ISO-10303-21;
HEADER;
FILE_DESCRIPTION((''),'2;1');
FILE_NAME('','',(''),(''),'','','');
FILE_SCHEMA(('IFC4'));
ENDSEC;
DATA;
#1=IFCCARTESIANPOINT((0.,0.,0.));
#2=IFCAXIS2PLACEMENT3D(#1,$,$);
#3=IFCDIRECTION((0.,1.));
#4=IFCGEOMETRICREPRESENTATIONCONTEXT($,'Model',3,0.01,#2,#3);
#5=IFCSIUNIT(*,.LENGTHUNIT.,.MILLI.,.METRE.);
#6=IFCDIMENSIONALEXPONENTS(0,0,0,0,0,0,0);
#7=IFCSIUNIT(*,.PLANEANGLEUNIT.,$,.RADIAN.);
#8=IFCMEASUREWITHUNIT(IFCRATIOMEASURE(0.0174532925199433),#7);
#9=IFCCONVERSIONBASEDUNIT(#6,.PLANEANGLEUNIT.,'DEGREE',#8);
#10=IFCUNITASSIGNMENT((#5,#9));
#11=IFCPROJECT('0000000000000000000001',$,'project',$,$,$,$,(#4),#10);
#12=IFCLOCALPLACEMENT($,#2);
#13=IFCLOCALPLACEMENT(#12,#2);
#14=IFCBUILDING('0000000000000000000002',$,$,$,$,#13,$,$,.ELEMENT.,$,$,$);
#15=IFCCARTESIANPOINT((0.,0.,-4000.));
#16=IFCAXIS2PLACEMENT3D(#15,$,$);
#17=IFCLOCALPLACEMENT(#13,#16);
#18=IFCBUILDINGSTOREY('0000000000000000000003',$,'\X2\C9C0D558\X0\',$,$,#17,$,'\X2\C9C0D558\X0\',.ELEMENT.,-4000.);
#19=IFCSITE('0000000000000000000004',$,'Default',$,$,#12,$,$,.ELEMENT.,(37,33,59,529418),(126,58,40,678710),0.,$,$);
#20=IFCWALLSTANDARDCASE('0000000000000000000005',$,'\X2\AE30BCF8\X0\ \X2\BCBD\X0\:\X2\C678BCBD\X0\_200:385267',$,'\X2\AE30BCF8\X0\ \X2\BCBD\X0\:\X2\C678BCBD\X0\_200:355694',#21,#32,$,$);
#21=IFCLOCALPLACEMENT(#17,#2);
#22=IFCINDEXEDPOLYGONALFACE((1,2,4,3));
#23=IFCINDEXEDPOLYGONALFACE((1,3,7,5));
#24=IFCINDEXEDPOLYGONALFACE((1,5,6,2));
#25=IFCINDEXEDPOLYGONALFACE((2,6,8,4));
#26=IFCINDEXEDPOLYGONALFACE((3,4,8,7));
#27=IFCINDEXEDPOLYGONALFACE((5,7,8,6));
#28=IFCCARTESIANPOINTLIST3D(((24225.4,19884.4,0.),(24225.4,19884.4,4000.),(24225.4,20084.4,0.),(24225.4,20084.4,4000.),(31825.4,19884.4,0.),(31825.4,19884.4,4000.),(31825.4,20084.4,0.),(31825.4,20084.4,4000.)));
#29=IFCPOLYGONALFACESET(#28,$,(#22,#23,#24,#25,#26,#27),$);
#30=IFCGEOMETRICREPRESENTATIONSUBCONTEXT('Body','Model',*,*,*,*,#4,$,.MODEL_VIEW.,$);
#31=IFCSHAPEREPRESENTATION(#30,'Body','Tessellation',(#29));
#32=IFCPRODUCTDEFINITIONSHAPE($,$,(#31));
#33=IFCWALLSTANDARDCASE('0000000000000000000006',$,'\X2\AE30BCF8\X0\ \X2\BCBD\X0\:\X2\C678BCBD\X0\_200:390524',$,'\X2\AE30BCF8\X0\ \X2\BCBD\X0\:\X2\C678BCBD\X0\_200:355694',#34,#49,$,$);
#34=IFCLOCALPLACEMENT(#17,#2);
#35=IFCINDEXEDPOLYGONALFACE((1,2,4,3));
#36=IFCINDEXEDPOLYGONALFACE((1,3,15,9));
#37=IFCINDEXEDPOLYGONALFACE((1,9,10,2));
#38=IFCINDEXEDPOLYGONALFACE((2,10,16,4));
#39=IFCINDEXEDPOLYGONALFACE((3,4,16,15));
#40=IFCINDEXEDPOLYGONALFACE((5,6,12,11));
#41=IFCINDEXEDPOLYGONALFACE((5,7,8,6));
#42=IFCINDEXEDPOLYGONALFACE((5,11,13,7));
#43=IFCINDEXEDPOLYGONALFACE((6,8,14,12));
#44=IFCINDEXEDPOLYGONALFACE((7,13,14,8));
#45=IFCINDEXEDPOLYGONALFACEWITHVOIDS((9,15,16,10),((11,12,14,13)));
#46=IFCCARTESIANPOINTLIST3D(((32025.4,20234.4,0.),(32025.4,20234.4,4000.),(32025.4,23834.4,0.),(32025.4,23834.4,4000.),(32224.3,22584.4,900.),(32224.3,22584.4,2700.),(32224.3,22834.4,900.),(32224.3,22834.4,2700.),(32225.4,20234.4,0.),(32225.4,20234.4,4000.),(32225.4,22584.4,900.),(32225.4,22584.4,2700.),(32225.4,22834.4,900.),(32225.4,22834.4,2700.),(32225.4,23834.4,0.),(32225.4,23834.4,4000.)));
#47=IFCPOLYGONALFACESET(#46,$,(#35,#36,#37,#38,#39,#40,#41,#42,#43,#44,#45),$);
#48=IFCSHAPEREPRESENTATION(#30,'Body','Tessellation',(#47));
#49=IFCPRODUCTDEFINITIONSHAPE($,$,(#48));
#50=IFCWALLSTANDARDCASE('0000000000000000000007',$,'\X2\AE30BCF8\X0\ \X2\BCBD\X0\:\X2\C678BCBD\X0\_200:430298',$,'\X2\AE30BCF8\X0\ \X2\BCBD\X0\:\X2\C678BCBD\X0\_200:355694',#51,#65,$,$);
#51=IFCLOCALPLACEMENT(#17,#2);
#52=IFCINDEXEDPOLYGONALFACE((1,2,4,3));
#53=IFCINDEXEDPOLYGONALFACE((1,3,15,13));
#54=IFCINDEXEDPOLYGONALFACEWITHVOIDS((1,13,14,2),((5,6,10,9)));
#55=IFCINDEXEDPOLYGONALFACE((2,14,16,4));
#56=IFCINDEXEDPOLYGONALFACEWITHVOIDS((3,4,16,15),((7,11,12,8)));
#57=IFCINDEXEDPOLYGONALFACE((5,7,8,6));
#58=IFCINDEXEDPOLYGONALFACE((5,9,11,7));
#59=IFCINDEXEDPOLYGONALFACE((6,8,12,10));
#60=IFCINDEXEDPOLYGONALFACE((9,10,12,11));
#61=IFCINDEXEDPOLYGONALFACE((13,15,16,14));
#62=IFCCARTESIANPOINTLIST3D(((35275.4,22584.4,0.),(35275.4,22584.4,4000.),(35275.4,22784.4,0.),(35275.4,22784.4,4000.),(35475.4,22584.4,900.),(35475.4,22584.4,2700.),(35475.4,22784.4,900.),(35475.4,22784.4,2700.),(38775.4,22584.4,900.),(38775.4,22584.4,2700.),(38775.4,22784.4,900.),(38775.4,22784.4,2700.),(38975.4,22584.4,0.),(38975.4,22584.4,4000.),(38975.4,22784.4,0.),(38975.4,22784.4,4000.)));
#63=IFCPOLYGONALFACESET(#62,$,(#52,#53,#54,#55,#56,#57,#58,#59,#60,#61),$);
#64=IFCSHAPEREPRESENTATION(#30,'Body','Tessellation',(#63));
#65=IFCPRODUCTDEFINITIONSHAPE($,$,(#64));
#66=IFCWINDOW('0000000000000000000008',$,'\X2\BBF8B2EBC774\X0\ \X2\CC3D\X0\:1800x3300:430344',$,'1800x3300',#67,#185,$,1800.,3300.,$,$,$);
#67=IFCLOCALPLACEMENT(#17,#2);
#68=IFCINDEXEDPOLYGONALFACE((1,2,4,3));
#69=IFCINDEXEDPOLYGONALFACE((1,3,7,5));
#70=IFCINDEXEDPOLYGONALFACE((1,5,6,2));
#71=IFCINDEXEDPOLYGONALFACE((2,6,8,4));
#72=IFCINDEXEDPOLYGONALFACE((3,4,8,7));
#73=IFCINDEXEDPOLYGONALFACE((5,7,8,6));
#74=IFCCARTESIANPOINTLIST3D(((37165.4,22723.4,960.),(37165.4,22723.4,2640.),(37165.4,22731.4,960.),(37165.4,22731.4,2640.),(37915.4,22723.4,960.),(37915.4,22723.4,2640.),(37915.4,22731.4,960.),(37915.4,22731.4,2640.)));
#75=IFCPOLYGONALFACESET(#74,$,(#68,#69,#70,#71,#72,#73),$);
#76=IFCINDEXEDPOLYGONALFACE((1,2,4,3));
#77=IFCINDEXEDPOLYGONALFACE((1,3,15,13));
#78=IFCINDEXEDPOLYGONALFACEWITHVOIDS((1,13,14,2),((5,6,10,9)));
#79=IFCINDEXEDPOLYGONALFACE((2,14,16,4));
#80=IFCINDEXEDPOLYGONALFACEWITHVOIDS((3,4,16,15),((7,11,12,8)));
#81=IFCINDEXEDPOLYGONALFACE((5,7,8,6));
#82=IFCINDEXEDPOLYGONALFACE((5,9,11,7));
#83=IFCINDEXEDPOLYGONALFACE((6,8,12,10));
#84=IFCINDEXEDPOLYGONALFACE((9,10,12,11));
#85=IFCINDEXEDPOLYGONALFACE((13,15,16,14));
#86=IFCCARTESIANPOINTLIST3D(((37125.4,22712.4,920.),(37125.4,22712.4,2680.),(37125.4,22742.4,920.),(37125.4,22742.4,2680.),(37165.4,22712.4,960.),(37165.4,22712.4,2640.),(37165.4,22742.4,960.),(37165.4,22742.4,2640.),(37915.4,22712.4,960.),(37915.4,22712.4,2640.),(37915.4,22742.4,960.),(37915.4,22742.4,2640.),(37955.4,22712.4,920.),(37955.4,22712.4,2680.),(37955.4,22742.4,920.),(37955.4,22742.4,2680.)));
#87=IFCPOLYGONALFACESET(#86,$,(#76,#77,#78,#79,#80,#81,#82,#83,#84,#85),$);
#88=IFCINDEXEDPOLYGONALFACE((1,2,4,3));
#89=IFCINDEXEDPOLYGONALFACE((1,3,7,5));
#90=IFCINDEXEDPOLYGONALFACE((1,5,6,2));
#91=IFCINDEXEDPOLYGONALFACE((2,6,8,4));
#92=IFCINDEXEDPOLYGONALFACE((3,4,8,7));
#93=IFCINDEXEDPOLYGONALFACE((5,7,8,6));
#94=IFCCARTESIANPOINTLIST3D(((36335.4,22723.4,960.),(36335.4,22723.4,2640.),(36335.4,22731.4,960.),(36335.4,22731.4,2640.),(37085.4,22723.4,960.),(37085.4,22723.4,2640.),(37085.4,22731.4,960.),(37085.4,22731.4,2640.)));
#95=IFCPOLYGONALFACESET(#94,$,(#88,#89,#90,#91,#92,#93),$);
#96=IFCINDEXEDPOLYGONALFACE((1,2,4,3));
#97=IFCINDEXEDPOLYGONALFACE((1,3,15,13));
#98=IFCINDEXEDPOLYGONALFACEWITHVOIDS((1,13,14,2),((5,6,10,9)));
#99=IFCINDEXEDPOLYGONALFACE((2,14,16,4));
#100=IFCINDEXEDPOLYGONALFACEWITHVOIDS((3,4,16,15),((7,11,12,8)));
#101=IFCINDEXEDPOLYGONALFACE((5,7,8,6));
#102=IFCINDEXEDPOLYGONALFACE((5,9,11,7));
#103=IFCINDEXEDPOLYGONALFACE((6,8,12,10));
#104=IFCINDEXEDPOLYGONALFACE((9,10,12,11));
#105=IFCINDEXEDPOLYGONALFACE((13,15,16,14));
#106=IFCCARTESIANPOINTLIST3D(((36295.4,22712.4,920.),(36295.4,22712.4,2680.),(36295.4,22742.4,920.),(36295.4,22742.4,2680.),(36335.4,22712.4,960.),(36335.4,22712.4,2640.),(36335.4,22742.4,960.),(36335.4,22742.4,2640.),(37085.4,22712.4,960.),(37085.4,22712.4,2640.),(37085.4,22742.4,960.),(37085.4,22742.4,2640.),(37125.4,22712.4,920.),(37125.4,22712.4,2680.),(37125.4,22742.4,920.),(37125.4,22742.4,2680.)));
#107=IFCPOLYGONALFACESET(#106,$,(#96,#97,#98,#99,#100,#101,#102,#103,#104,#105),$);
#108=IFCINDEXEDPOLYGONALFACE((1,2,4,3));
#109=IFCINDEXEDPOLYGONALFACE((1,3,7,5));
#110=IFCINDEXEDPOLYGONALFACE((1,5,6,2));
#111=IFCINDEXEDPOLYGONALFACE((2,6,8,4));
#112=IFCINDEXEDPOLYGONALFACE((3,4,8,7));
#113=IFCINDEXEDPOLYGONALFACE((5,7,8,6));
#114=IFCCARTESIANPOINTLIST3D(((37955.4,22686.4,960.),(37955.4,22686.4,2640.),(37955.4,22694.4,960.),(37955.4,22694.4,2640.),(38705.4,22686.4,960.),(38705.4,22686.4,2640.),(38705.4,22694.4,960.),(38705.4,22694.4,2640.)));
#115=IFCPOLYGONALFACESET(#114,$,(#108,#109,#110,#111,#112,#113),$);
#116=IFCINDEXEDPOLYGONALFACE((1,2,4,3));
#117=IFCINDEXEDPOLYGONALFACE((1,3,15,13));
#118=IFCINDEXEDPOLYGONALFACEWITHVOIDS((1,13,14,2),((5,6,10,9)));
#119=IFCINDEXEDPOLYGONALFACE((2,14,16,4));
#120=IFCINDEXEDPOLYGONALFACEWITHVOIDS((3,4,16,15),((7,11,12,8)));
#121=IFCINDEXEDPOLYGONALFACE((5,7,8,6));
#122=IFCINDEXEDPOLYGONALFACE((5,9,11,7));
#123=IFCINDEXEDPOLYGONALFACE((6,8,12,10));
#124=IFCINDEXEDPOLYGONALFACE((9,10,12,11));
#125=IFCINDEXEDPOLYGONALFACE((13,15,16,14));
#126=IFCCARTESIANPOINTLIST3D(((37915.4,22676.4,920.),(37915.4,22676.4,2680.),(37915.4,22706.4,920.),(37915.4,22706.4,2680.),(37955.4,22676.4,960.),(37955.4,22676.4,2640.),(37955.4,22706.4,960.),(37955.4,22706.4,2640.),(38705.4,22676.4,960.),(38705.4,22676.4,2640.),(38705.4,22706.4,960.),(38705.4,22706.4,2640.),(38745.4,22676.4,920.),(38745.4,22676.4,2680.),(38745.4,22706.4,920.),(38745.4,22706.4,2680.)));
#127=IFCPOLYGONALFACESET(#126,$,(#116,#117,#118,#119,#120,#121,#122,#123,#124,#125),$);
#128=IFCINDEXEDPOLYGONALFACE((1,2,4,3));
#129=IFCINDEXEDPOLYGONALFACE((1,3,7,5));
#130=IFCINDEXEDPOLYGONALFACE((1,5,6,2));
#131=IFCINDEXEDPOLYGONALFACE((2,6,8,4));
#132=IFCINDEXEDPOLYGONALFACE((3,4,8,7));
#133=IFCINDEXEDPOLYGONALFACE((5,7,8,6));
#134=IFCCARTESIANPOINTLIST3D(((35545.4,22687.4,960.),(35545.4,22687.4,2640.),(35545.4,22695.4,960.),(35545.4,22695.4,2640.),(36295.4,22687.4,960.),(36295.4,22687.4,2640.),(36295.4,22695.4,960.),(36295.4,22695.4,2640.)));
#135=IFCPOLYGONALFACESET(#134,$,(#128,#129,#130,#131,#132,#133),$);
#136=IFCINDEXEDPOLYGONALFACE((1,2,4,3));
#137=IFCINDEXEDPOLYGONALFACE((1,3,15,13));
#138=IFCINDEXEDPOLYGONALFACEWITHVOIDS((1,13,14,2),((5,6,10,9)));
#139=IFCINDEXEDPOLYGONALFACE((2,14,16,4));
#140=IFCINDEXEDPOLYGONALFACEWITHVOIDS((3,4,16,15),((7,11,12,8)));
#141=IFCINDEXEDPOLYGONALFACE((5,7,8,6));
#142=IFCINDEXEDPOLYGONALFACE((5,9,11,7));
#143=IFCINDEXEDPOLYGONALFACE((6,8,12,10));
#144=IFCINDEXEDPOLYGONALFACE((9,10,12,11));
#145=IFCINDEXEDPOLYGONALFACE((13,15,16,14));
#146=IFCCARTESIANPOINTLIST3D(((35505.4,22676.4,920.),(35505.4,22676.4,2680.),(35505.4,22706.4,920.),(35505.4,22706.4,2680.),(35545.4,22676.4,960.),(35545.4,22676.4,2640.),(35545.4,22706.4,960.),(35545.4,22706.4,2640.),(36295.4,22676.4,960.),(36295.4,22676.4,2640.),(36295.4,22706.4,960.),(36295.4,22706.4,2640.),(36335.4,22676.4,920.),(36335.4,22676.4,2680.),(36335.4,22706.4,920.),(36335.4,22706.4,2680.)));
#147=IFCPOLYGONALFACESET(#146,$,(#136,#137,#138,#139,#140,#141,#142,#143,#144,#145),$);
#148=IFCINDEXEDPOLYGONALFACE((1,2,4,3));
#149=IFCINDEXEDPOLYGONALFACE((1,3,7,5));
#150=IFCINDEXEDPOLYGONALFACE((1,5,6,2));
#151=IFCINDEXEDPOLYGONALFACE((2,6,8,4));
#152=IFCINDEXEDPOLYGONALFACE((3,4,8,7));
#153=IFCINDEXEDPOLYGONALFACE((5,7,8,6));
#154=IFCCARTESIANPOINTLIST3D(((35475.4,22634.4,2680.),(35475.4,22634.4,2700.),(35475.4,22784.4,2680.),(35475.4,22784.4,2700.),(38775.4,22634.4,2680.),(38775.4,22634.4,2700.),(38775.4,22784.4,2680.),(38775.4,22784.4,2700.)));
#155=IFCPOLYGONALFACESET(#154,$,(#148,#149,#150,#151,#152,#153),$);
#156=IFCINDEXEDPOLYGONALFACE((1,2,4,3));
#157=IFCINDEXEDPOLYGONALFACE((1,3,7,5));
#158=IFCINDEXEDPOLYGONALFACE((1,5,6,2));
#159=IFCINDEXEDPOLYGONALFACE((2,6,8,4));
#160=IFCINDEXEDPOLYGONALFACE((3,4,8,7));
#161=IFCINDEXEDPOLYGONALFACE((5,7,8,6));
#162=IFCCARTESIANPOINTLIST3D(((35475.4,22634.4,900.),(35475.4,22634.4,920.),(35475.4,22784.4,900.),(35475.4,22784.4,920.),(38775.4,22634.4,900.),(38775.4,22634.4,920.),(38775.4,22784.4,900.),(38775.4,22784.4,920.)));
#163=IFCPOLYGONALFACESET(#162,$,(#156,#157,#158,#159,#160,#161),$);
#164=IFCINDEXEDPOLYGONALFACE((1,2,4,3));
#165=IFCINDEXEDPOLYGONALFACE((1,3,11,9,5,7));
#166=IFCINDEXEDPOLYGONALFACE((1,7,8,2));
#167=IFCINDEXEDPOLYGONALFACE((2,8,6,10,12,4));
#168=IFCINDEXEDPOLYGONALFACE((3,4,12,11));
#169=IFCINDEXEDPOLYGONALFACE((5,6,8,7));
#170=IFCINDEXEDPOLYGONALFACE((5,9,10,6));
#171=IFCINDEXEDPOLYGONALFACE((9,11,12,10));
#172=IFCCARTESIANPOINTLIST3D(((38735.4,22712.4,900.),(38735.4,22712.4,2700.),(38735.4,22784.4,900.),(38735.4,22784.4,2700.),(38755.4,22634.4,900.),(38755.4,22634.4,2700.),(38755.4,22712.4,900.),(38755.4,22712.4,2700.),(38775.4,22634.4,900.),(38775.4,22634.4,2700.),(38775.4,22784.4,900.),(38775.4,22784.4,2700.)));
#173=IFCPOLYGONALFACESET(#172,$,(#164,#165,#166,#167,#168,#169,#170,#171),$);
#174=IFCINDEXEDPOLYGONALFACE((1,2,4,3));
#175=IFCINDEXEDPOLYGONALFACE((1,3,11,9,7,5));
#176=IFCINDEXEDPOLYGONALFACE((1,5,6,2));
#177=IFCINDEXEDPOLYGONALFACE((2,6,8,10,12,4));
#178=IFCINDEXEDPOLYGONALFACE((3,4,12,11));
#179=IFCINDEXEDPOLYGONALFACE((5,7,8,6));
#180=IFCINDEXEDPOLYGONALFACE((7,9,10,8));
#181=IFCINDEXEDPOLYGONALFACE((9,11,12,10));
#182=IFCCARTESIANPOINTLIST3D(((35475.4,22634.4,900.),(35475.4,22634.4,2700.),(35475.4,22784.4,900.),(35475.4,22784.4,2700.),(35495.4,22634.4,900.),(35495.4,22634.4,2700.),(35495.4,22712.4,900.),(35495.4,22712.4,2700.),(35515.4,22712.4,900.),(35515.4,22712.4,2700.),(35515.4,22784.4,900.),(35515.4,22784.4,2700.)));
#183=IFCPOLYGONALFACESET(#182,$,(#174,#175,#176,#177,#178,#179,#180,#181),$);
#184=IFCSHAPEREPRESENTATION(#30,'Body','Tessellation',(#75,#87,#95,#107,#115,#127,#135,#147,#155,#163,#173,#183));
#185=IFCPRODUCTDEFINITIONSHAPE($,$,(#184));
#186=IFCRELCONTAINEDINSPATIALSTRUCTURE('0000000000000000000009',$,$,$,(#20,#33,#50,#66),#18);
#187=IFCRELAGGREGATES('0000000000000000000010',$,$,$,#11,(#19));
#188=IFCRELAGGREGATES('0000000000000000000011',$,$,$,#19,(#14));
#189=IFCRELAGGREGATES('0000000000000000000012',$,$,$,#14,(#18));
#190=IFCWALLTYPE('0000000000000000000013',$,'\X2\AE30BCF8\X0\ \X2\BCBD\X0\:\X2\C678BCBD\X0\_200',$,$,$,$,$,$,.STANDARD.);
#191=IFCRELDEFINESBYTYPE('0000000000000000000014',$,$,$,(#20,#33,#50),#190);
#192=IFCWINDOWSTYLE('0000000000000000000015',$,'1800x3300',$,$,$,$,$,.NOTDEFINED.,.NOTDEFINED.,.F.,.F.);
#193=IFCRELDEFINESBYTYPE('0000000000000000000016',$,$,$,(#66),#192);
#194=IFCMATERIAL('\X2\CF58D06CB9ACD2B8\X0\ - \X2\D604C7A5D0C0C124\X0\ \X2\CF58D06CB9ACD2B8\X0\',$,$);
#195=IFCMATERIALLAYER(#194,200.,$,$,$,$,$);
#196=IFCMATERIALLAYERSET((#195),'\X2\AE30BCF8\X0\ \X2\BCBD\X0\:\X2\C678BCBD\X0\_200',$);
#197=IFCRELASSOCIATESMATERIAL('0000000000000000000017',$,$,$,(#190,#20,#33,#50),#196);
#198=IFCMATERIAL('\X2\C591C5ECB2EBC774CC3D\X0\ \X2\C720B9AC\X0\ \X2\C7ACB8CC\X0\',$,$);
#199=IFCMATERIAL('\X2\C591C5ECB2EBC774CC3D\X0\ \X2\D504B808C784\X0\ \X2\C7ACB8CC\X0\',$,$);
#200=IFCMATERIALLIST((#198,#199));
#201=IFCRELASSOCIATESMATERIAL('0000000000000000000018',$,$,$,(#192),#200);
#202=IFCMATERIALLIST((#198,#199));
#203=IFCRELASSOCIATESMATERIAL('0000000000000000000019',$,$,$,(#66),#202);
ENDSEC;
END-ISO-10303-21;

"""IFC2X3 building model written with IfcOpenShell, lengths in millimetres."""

from ifc_helpers import new_model, entity, si_unit, converted_unit, direction, frame, frame_2d, origin, origin_2d_with_axis, place, context, subcontext, project, spatial, polyline, rectangle, outline, extrude, source, transform, mapped, material, material_list, layer, layer_set, layer_usage, type_object, type_shapes, element, fill, save


model = new_model("IFC2X3")

# Units and contexts
model_context = context("Model", 3, precision=0.01, world=origin(), true_north=direction((0.0, 1.0)))
body_context = subcontext(model_context, "Body", "Model", "MODEL_VIEW")
ifc_project = project(units=[si_unit("LENGTHUNIT", "METRE", prefix="MILLI"), converted_unit("PLANEANGLEUNIT", "DEGREE", entity("IfcRatioMeasure", 0.0174532925199433), si_unit("PLANEANGLEUNIT", "RADIAN"), dimensions=[0, 0, 0, 0, 0, 0, 0])], contexts=[model_context])

# Site, building, storey
site_placement = place(None, origin())
site = spatial("IfcSite", under=ifc_project, at=site_placement, Name="Default", CompositionType="ELEMENT", RefLatitude=(37, 33, 59, 529418), RefLongitude=(126, 58, 40, 678710), RefElevation=0.0)
building_placement = place(site_placement, origin())
building = spatial("IfcBuilding", under=site, at=building_placement, CompositionType="ELEMENT")
storey_placement = place(building_placement, frame((0.0, 0.0, -4000.0)))
storey = spatial("IfcBuildingStorey", under=building, at=storey_placement, Name="지하", LongName="지하", CompositionType="ELEMENT", Elevation=-4000.0)

# Wall
ifc_material_1 = material(Name="콘크리트 - 현장타설 콘크리트")
ifc_layer_1 = layer(ifc_material_1, 200.0)
ifc_layer_set_1 = layer_set([ifc_layer_1], Name="기본 벽:외벽_200")
ifc_layer_usage_1 = layer_usage(ifc_layer_set_1, "AXIS2", "NEGATIVE", 100.0)
wall_type_1 = type_object("IfcWallType", Name="기본 벽:외벽_200", PredefinedType="STANDARD", material=ifc_layer_set_1)
wall_1_placement = place(storey_placement, frame((31825.4, 19984.4, 0.0), z_axis=(0.0, 0.0, 1.0), x_axis=(-1.0, 0.0, 0.0)))
element("IfcWallStandardCase", 1, at=wall_1_placement, inside=storey, type_object=wall_type_1, material=ifc_layer_usage_1, Name="기본 벽:외벽_200:385267", ObjectType="기본 벽:외벽_200:355694", context=body_context, shape_type="SweptSolid", body=[
    extrude(rectangle(XDim=7600.0, YDim=200.0, at=frame_2d((3800.0, 0.0), x_axis=(-1.0, 0.0))), origin(), (0.0, 0.0, 1.0), 4000.0),
])

# Wall, opening
ifc_layer_usage_2 = layer_usage(ifc_layer_set_1, "AXIS2", "NEGATIVE", 100.0)
wall_2_placement = place(storey_placement, frame((32125.4, 23834.4, 0.0), z_axis=(0.0, 0.0, 1.0), x_axis=(0.0, -1.0, 0.0)))
wall_2 = element("IfcWallStandardCase", 2, at=wall_2_placement, inside=storey, type_object=wall_type_1, material=ifc_layer_usage_2, Name="기본 벽:외벽_200:390524", ObjectType="기본 벽:외벽_200:355694", context=body_context, shape_type="SweptSolid", body=[
    extrude(rectangle(XDim=3600.0, YDim=200.0, at=frame_2d((1800.0, 0.0), x_axis=(-1.0, 0.0))), origin(), (0.0, 0.0, 1.0), 4000.0),
])
opening_1_placement = place(wall_2_placement, origin())
element("IfcOpeningElement", 3, at=opening_1_placement, cuts=wall_2, ObjectType="Opening", context=body_context, shape_type="SweptSolid", body=[
    extrude(rectangle(XDim=1800.0, YDim=250.0, at=frame_2d((0.0, 0.0), x_axis=(0.0, 1.0))), frame((1125.0, 98.9, 1800.0), z_axis=(0.0, 1.0, 0.0), x_axis=(1.0, 0.0, 0.0)), (0.0, 0.0, 1.0), 2700.0),
])

# Wall, opening, window
ifc_layer_usage_3 = layer_usage(ifc_layer_set_1, "AXIS2", "NEGATIVE", 100.0)
wall_3_placement = place(storey_placement, frame((35275.4, 22684.4, 0.0)))
wall_3 = element("IfcWallStandardCase", 4, at=wall_3_placement, inside=storey, type_object=wall_type_1, material=ifc_layer_usage_3, Name="기본 벽:외벽_200:430298", ObjectType="기본 벽:외벽_200:355694", context=body_context, shape_type="SweptSolid", body=[
    extrude(rectangle(XDim=3700.0, YDim=200.0, at=frame_2d((1850.0, 0.0), x_axis=(-1.0, 0.0))), origin(), (0.0, 0.0, 1.0), 4000.0),
])
opening_2_placement = place(wall_3_placement, frame((200.0, -100.0, 900.0)))
opening_2 = element("IfcOpeningElement", 5, at=opening_2_placement, cuts=wall_3, ObjectType="Opening", context=body_context, shape_type="SweptSolid", body=[
    extrude(rectangle(XDim=1800.0, YDim=3300.0, at=frame_2d((900.0, 1650.0), x_axis=(1.0, 0.0))), frame((0.0, 0.0, 0.0), z_axis=(0.0, 1.0, 0.0), x_axis=(0.0, 0.0, 1.0)), (0.0, 0.0, 1.0), 200.0),
])
ifc_material_2 = material(Name="양여닫이창 유리 재료")
ifc_material_3 = material(Name="양여닫이창 프레임 재료")
ifc_material_list_1 = material_list([ifc_material_2, ifc_material_3])
ifc_material_list_2 = material_list([ifc_material_2, ifc_material_3])
window_style_1 = type_object("IfcWindowStyle", Name="1800x3300", ConstructionType="NOTDEFINED", OperationType="NOTDEFINED", ParameterTakesPrecedence=False, Sizeable=False, material=ifc_material_list_2)
shared_shape_1 = source(origin(), body_context, "Body", "SweptSolid", [
    extrude(rectangle(XDim=8.0, YDim=750.0, at=frame_2d((0.0, 0.0), x_axis=(1.0, 0.0))), frame((2065.0, 143.0, 60.0), z_axis=(0.0, 0.0, 1.0), x_axis=(0.0, 1.0, 0.0)), (0.0, 0.0, 1.0), 1680.0),
    extrude(outline(polyline([(-880.0, -415.0), (880.0, -415.0), (880.0, 415.0), (-880.0, 415.0), (-880.0, -415.0)]), holes=[polyline([(840.0, -375.0), (-840.0, -375.0), (-840.0, 375.0), (840.0, 375.0), (840.0, -375.0)])]), frame((2065.0, 128.0, 900.0), z_axis=(0.0, 1.0, 0.0), x_axis=(0.0, 0.0, -1.0)), (0.0, 0.0, 1.0), 30.0),
    extrude(rectangle(XDim=8.0, YDim=750.0, at=frame_2d((0.0, 0.0), x_axis=(1.0, 0.0))), frame((1235.0, 143.0, 60.0), z_axis=(0.0, 0.0, 1.0), x_axis=(0.0, 1.0, 0.0)), (0.0, 0.0, 1.0), 1680.0),
    extrude(outline(polyline([(-880.0, -415.0), (880.0, -415.0), (880.0, 415.0), (-880.0, 415.0), (-880.0, -415.0)]), holes=[polyline([(840.0, -375.0), (-840.0, -375.0), (-840.0, 375.0), (840.0, 375.0), (840.0, -375.0)])]), frame((1235.0, 128.0, 900.0), z_axis=(0.0, 1.0, 0.0), x_axis=(0.0, 0.0, -1.0)), (0.0, 0.0, 1.0), 30.0),
    extrude(rectangle(XDim=8.0, YDim=750.0, at=frame_2d((0.0, 0.0), x_axis=(1.0, 0.0))), frame((2855.0, 106.0, 60.0), z_axis=(0.0, 0.0, 1.0), x_axis=(0.0, 1.0, 0.0)), (0.0, 0.0, 1.0), 1680.0),
    extrude(outline(polyline([(-880.0, -415.0), (880.0, -415.0), (880.0, 415.0), (-880.0, 415.0), (-880.0, -415.0)]), holes=[polyline([(840.0, -375.0), (-840.0, -375.0), (-840.0, 375.0), (840.0, 375.0), (840.0, -375.0)])]), frame((2855.0, 92.0, 900.0), z_axis=(0.0, 1.0, 0.0), x_axis=(0.0, 0.0, -1.0)), (0.0, 0.0, 1.0), 30.0),
    extrude(rectangle(XDim=8.0, YDim=750.0, at=origin_2d_with_axis()), frame((445.0, 107.0, 60.0), z_axis=(0.0, 0.0, 1.0), x_axis=(0.0, 1.0, 0.0)), (0.0, 0.0, 1.0), 1680.0),
    extrude(outline(polyline([(-880.0, -415.0), (880.0, -415.0), (880.0, 415.0), (-880.0, 415.0), (-880.0, -415.0)]), holes=[polyline([(840.0, -375.0), (-840.0, -375.0), (-840.0, 375.0), (840.0, 375.0), (840.0, -375.0)])]), frame((445.0, 92.0, 900.0), z_axis=(0.0, 1.0, 0.0), x_axis=(0.0, 0.0, -1.0)), (0.0, 0.0, 1.0), 30.0),
    extrude(rectangle(XDim=3300.0, YDim=150.0, at=origin_2d_with_axis()), frame((1650.0, 125.0, 1780.0), z_axis=(0.0, 0.0, 1.0), x_axis=(-1.0, 0.0, 0.0)), (0.0, 0.0, 1.0), 20.0),
    extrude(rectangle(XDim=3300.0, YDim=150.0, at=origin_2d_with_axis()), frame((1650.0, 125.0, 0.0), z_axis=(0.0, 0.0, 1.0), x_axis=(-1.0, 0.0, 0.0)), (0.0, 0.0, 1.0), 20.0),
    extrude(outline(polyline([(-74.0, -20.0), (-2.0, -20.0), (-2.0, 0.0), (76.0, 0.0), (76.0, 20.0), (-74.0, 20.0), (-74.0, -20.0)])), frame((3280.0, 126.0, 0.0), z_axis=(0.0, 0.0, 1.0), x_axis=(0.0, -1.0, 0.0)), (0.0, 0.0, 1.0), 1800.0),
    extrude(outline(polyline([(-20.0, -74.0), (20.0, -74.0), (20.0, 76.0), (0.0, 76.0), (0.0, -2.0), (-20.0, -2.0), (-20.0, -74.0)])), frame((20.0, 126.0, 0.0), z_axis=(0.0, 0.0, 1.0), x_axis=(-1.0, 0.0, 0.0)), (0.0, 0.0, 1.0), 1800.0),
])
type_shapes(window_style_1, [shared_shape_1])
window_1_placement = place(opening_2_placement, origin())
window_1 = element("IfcWindow", 6, at=window_1_placement, inside=storey, type_object=window_style_1, material=ifc_material_list_1, Name="미닫이 창:1800x3300:430344", ObjectType="1800x3300", OverallHeight=1800.0, OverallWidth=3300.0, context=body_context, shape_type="MappedRepresentation", body=[
    mapped(shared_shape_1, transform((0.0, 0.0, 0.0), scale=1.0)),
])
fill(opening_2, window_1)

save(model, "model.ifc")
